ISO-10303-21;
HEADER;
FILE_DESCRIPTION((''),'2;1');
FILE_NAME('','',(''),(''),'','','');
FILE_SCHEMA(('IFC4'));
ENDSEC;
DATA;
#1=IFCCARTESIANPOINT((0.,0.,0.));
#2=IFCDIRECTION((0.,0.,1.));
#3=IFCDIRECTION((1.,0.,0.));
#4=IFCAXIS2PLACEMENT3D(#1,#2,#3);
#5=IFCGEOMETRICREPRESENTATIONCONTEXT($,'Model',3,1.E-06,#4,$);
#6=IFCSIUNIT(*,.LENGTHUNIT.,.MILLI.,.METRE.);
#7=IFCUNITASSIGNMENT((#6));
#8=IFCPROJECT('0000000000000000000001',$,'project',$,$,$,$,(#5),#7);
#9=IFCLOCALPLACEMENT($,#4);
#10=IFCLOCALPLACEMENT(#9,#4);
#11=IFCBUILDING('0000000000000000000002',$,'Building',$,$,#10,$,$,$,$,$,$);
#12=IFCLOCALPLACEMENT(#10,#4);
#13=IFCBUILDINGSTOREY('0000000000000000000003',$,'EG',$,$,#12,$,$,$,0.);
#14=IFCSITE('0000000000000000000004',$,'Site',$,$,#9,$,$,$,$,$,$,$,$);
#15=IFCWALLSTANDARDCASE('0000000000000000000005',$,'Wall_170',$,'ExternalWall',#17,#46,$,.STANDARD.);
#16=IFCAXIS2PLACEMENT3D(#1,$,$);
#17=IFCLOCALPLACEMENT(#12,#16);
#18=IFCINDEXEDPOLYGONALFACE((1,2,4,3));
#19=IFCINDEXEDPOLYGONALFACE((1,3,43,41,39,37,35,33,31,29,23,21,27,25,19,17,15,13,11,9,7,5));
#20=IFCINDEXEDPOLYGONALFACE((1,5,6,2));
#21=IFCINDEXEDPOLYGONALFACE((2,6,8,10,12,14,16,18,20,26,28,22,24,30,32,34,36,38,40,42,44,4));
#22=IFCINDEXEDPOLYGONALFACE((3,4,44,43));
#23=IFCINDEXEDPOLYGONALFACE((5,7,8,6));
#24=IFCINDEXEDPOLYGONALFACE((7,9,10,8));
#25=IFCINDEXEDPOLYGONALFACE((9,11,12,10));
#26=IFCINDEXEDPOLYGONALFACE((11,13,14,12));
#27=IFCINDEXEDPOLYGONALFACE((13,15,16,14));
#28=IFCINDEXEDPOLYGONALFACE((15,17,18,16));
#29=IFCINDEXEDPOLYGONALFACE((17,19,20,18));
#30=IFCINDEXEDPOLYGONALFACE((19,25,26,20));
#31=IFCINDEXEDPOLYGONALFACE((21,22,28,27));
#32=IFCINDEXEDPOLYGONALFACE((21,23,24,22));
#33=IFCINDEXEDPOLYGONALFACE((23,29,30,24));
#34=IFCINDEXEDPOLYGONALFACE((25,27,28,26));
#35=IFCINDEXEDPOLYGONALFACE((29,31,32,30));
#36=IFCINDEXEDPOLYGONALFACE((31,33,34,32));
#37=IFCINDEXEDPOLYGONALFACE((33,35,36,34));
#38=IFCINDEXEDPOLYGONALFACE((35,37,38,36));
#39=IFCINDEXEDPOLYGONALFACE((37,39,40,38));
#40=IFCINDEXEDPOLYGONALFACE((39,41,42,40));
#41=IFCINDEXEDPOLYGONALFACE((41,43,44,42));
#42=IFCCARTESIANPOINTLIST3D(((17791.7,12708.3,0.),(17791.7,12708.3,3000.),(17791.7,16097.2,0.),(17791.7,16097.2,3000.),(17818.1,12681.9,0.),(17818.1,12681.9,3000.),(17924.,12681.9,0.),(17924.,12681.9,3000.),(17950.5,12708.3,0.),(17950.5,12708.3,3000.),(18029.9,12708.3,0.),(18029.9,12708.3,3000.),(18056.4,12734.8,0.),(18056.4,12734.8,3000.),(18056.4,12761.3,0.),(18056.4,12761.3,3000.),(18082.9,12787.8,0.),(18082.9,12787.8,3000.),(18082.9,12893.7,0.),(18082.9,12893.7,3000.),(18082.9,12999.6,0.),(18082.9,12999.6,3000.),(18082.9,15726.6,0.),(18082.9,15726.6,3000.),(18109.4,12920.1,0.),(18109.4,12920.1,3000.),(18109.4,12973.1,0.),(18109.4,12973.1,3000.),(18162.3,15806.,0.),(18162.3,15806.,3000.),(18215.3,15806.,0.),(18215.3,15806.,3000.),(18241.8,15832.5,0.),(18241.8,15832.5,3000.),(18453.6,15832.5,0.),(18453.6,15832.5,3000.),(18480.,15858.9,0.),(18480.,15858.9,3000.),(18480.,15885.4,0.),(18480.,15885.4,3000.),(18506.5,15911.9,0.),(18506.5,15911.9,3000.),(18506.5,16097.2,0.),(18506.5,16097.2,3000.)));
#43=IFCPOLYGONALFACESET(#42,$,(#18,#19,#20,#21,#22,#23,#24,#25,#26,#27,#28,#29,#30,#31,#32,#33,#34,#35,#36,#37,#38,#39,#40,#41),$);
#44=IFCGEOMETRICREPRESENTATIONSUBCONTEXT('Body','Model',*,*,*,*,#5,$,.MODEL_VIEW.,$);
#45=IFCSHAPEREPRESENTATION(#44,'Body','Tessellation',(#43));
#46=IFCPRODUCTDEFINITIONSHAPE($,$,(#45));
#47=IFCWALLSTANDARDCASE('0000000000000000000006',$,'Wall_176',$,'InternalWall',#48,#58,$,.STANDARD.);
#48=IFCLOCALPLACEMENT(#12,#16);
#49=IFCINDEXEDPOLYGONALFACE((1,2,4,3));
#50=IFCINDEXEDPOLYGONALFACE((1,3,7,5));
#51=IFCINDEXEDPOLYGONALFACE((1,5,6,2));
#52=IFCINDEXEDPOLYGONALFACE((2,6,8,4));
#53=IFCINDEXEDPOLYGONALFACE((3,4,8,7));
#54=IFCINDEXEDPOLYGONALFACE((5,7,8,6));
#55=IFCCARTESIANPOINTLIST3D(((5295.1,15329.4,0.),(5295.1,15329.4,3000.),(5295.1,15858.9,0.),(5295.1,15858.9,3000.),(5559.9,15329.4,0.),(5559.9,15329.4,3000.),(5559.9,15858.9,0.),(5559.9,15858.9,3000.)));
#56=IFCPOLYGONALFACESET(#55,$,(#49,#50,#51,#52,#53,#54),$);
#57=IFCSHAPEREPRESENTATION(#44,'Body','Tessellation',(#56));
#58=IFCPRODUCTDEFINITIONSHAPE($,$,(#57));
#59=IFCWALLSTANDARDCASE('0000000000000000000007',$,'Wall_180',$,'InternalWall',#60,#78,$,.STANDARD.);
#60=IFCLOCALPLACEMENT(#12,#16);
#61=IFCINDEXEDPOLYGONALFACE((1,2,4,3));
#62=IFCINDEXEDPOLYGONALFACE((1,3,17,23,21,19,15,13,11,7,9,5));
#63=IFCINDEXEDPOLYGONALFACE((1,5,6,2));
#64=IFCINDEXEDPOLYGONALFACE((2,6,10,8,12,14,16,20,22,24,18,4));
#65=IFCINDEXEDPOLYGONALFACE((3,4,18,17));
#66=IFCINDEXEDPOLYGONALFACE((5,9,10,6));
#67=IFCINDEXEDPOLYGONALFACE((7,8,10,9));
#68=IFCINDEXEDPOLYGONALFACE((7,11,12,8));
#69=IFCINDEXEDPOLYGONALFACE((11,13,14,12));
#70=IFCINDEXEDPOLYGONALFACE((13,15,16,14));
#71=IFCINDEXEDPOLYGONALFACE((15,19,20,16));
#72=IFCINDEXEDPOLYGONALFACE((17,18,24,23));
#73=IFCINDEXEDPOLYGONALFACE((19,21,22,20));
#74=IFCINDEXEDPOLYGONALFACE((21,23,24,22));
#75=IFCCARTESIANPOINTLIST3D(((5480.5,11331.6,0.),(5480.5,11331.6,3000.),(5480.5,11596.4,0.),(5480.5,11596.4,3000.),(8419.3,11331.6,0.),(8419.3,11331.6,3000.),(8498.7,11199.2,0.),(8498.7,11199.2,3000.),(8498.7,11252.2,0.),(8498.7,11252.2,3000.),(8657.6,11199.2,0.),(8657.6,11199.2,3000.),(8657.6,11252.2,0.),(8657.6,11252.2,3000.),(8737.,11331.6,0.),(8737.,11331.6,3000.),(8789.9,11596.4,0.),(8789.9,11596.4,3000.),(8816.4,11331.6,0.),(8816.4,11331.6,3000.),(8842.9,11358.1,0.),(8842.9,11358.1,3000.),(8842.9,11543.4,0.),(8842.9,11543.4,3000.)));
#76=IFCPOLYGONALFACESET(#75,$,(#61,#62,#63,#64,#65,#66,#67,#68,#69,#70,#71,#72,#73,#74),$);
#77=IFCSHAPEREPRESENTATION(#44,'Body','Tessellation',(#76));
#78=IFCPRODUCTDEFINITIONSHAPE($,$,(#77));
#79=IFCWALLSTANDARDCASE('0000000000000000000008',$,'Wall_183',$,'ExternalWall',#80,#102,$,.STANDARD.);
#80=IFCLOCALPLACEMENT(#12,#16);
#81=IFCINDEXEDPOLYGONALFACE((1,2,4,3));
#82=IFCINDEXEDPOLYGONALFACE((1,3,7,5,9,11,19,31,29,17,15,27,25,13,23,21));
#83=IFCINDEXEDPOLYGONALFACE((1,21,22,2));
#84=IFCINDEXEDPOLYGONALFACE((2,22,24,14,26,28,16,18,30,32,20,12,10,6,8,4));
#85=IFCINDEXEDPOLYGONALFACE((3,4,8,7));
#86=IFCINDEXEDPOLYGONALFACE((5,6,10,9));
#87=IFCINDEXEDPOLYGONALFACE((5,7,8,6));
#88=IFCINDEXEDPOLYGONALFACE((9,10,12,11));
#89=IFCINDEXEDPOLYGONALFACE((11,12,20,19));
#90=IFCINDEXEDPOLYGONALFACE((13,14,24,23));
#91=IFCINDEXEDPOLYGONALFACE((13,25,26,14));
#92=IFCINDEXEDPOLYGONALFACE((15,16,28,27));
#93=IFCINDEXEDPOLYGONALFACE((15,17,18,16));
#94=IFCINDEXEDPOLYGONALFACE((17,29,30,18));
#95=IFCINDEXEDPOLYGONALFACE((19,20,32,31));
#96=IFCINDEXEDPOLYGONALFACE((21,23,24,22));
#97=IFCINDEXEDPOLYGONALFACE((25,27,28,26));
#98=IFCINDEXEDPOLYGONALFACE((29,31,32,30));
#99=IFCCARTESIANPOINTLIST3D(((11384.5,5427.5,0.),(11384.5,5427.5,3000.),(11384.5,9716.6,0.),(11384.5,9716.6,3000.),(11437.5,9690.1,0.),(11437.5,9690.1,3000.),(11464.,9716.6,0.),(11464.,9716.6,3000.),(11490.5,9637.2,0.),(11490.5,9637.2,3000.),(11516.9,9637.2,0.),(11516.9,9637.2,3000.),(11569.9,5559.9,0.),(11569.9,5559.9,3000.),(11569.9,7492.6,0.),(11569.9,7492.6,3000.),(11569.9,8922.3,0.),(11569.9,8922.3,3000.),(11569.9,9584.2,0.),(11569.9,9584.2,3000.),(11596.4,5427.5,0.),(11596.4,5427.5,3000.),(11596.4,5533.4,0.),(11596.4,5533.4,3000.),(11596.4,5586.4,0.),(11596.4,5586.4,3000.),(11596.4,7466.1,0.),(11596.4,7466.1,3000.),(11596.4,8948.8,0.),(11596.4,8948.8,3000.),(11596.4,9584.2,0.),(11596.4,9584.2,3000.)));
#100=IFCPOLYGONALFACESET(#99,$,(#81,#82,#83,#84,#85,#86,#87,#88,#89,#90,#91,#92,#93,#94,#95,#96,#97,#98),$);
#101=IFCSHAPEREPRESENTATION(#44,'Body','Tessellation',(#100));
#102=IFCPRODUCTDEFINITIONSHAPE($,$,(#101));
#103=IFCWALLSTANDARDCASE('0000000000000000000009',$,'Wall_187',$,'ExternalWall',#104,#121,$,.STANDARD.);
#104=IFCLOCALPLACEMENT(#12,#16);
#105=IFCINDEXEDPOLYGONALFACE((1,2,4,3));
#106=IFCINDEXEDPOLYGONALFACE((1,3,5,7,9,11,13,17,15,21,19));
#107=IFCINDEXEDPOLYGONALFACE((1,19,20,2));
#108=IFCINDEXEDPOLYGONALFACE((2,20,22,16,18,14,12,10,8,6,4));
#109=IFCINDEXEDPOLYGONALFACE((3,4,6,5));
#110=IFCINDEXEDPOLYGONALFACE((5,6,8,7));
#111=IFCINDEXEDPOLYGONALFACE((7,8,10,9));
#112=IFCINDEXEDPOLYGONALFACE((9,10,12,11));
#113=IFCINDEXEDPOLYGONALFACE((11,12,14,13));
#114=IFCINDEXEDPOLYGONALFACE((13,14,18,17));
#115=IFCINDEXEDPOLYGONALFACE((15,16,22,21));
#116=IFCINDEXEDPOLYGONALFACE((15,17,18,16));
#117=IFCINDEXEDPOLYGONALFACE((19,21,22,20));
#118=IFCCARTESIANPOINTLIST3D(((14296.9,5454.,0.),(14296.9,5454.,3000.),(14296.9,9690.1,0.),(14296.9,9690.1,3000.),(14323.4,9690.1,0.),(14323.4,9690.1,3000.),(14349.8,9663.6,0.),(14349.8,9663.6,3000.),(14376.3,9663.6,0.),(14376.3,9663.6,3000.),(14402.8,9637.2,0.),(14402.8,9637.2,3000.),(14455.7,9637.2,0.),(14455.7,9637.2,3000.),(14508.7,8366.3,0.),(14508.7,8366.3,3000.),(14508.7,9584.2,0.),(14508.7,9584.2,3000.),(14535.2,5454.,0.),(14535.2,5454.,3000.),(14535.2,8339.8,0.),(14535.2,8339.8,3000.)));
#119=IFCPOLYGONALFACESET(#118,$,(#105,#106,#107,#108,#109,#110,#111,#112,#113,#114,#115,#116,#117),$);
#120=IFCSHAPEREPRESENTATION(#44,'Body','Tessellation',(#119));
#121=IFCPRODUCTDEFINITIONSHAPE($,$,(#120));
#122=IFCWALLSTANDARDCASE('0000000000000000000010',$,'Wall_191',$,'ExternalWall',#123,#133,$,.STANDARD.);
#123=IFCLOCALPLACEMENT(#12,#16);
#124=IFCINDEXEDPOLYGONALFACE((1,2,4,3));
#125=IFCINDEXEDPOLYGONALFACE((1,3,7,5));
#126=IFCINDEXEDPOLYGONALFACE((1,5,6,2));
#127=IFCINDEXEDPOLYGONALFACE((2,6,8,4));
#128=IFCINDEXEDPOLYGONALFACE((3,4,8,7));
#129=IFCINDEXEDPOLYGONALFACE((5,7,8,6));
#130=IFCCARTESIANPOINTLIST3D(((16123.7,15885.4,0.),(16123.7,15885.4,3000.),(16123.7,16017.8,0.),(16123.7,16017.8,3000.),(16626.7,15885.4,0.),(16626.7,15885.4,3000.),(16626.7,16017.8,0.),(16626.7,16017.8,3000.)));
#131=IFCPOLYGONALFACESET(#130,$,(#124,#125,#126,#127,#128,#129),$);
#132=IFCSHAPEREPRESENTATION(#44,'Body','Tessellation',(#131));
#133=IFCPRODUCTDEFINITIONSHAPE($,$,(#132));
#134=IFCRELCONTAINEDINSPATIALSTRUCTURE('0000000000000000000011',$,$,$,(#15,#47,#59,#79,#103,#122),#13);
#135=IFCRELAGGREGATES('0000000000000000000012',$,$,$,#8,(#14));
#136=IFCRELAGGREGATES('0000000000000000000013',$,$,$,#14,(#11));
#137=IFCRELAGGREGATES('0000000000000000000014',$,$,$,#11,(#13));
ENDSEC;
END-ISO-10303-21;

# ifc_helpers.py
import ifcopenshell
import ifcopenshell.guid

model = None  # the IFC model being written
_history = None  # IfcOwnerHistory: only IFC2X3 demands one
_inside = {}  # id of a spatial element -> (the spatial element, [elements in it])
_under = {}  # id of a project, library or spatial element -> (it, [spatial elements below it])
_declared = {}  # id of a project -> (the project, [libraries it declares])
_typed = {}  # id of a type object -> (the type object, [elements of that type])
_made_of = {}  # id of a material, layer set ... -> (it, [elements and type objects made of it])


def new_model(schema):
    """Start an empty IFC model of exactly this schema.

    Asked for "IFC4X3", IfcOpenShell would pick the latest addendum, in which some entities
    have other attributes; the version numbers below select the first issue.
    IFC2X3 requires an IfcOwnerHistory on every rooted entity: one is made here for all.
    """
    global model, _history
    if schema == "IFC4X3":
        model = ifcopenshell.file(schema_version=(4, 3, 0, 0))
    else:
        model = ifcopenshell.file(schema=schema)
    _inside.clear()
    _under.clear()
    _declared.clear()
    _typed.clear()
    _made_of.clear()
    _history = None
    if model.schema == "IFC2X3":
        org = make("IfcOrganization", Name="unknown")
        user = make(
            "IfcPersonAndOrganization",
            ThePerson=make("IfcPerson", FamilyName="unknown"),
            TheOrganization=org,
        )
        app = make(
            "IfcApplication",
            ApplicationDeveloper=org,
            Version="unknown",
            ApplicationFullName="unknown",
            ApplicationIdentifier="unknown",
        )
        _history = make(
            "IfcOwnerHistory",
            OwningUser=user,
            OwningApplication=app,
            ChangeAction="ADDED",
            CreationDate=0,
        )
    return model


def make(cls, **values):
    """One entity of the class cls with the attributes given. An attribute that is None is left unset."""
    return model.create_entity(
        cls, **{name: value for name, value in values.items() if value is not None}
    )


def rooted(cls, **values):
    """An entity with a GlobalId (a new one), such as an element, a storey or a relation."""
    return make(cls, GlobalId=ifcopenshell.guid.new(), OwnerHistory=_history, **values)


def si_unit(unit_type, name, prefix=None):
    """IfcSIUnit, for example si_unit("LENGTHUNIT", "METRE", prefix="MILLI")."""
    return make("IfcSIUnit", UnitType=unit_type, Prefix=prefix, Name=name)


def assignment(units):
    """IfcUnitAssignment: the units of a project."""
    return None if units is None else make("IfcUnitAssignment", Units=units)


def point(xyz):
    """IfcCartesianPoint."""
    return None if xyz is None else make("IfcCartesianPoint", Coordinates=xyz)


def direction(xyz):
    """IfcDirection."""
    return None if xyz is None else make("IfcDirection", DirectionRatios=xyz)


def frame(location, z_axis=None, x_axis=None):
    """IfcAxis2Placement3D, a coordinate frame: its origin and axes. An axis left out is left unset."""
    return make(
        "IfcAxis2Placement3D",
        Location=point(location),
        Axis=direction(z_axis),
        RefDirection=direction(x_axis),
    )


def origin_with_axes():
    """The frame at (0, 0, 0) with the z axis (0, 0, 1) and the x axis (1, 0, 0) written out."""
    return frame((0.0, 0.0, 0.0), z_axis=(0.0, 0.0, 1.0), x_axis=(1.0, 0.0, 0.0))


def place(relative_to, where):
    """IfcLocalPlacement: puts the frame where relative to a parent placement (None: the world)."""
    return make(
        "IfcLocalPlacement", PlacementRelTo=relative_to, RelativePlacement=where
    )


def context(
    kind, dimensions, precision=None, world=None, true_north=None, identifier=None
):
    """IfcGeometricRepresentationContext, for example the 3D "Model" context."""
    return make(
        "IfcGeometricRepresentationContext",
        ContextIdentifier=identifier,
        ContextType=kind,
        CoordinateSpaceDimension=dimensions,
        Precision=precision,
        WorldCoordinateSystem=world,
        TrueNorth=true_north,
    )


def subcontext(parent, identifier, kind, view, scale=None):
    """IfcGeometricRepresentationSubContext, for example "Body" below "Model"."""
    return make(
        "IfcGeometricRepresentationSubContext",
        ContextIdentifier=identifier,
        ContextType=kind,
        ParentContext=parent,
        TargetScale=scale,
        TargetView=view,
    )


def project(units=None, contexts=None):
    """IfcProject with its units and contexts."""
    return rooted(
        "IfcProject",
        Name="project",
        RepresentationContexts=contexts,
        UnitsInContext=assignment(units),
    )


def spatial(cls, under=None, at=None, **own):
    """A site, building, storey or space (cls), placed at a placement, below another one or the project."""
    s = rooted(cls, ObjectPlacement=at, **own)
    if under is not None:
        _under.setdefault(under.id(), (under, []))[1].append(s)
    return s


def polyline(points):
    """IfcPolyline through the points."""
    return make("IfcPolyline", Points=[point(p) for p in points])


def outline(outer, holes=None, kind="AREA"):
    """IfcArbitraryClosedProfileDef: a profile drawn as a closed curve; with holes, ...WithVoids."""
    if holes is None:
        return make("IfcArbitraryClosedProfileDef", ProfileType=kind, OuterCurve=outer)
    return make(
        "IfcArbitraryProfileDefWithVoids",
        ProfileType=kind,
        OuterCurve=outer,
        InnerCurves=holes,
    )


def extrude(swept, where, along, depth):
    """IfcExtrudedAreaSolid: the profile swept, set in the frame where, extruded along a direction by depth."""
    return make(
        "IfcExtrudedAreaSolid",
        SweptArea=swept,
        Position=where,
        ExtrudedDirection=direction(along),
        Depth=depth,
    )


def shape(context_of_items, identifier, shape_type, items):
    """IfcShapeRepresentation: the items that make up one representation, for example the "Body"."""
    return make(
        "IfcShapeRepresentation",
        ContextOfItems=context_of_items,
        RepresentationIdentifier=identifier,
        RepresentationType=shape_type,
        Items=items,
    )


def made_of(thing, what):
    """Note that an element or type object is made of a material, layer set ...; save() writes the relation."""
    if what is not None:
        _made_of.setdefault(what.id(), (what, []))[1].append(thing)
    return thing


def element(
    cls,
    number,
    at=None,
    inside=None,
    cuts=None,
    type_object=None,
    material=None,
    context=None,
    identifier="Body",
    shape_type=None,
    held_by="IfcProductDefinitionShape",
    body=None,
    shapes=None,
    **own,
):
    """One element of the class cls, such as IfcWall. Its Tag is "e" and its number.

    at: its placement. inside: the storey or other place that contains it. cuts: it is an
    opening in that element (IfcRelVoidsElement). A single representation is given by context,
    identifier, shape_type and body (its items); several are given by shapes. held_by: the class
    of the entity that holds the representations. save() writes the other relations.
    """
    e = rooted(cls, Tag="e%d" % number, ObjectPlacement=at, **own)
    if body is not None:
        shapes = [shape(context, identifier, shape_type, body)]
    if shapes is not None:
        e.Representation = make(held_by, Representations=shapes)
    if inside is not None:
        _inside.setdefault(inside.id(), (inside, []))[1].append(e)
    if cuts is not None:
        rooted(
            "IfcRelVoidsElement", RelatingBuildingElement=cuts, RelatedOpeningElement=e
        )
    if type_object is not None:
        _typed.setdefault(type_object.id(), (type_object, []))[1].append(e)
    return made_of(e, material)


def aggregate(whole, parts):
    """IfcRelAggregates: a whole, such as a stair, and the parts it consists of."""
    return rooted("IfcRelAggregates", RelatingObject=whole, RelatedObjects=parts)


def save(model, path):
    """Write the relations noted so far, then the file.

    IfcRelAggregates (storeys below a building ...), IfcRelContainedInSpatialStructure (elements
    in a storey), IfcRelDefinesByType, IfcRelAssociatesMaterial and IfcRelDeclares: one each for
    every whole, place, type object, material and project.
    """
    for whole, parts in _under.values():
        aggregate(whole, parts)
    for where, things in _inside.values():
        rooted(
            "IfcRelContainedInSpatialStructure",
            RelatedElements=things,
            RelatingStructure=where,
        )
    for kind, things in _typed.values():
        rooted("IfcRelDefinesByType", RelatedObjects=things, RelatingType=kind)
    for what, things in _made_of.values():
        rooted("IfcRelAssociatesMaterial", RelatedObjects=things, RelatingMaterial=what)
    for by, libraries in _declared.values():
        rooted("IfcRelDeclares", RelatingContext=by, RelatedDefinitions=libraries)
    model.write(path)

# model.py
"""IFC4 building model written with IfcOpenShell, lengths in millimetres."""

from ifc_helpers import new_model, si_unit, frame, origin_with_axes, place, context, subcontext, project, spatial, polyline, outline, extrude, element, save


model = new_model("IFC4")

# Units and contexts
model_context = context("Model", 3, precision=1e-06, world=origin_with_axes())
body_context = subcontext(model_context, "Body", "Model", "MODEL_VIEW")
ifc_project = project(units=[si_unit("LENGTHUNIT", "METRE", prefix="MILLI")], contexts=[model_context])

# Site, building, storey
site_placement = place(None, origin_with_axes())
site = spatial("IfcSite", under=ifc_project, at=site_placement, Name="Site")
building_placement = place(site_placement, origin_with_axes())
building = spatial("IfcBuilding", under=site, at=building_placement, Name="Building")
storey_placement = place(building_placement, origin_with_axes())
storey = spatial("IfcBuildingStorey", under=building, at=storey_placement, Name="EG", Elevation=0.0)

# Walls
for number, where, z_axis, x_axis, name in (
    (1, (0.0, 0.0, 0.0), (0.0, 0.0, 1.0), (1.0, 0.0, 0.0), "Wall_170"),
):
    element("IfcWallStandardCase", number, at=place(storey_placement, frame(where, z_axis=z_axis, x_axis=x_axis)), inside=storey, Name=name, ObjectType="ExternalWall", PredefinedType="STANDARD", context=body_context, shape_type="SweptSolid", body=[
        extrude(outline(polyline([(17818.1, 12681.9, 0.0), (17791.7, 12708.3, 0.0), (17791.7, 16097.2, 0.0), (18506.5, 16097.2, 0.0), (18506.5, 15911.9, 0.0), (18480.0, 15885.4, 0.0), (18480.0, 15858.9, 0.0), (18453.6, 15832.5, 0.0), (18241.8, 15832.5, 0.0), (18215.3, 15806.0, 0.0), (18162.3, 15806.0, 0.0), (18082.9, 15726.6, 0.0), (18082.9, 12999.6, 0.0), (18109.4, 12973.1, 0.0), (18109.4, 12920.1, 0.0), (18082.9, 12893.7, 0.0), (18082.9, 12787.8, 0.0), (18056.4, 12761.3, 0.0), (18056.4, 12734.8, 0.0), (18029.9, 12708.3, 0.0), (17950.5, 12708.3, 0.0), (17924.0, 12681.9, 0.0), (17818.1, 12681.9, 0.0)])), origin_with_axes(), (0.0, 0.0, 1.0), 3000.0),
    ])
for number, where, z_axis, x_axis, name in (
    (2, (0.0, 0.0, 0.0), (0.0, 0.0, 1.0), (1.0, 0.0, 0.0), "Wall_176"),
):
    element("IfcWallStandardCase", number, at=place(storey_placement, frame(where, z_axis=z_axis, x_axis=x_axis)), inside=storey, Name=name, ObjectType="InternalWall", PredefinedType="STANDARD", context=body_context, shape_type="SweptSolid", body=[
        extrude(outline(polyline([(5295.1, 15329.4, 0.0), (5295.1, 15858.9, 0.0), (5559.9, 15858.9, 0.0), (5559.9, 15329.4, 0.0), (5295.1, 15329.4, 0.0)])), origin_with_axes(), (0.0, 0.0, 1.0), 3000.0),
    ])
for number, where, z_axis, x_axis, name in (
    (3, (0.0, 0.0, 0.0), (0.0, 0.0, 1.0), (1.0, 0.0, 0.0), "Wall_180"),
):
    element("IfcWallStandardCase", number, at=place(storey_placement, frame(where, z_axis=z_axis, x_axis=x_axis)), inside=storey, Name=name, ObjectType="InternalWall", PredefinedType="STANDARD", context=body_context, shape_type="SweptSolid", body=[
        extrude(outline(polyline([(8498.7, 11199.2, 0.0), (8498.7, 11252.2, 0.0), (8419.3, 11331.6, 0.0), (5480.5, 11331.6, 0.0), (5480.5, 11596.4, 0.0), (8789.9, 11596.4, 0.0), (8842.9, 11543.4, 0.0), (8842.9, 11358.1, 0.0), (8816.4, 11331.6, 0.0), (8737.0, 11331.6, 0.0), (8657.6, 11252.2, 0.0), (8657.6, 11199.2, 0.0), (8498.7, 11199.2, 0.0)])), origin_with_axes(), (0.0, 0.0, 1.0), 3000.0),
    ])
for number, where, z_axis, x_axis, name in (
    (4, (0.0, 0.0, 0.0), (0.0, 0.0, 1.0), (1.0, 0.0, 0.0), "Wall_183"),
):
    element("IfcWallStandardCase", number, at=place(storey_placement, frame(where, z_axis=z_axis, x_axis=x_axis)), inside=storey, Name=name, ObjectType="ExternalWall", PredefinedType="STANDARD", context=body_context, shape_type="SweptSolid", body=[
        extrude(outline(polyline([(11384.5, 5427.5, 0.0), (11384.5, 9716.6, 0.0), (11464.0, 9716.6, 0.0), (11437.5, 9690.1, 0.0), (11490.5, 9637.2, 0.0), (11516.9, 9637.2, 0.0), (11569.9, 9584.2, 0.0), (11596.4, 9584.2, 0.0), (11596.4, 8948.8, 0.0), (11569.9, 8922.3, 0.0), (11569.9, 7492.6, 0.0), (11596.4, 7466.1, 0.0), (11596.4, 5586.4, 0.0), (11569.9, 5559.9, 0.0), (11596.4, 5533.4, 0.0), (11596.4, 5427.5, 0.0), (11384.5, 5427.5, 0.0)])), origin_with_axes(), (0.0, 0.0, 1.0), 3000.0),
    ])
for number, where, z_axis, x_axis, name in (
    (5, (0.0, 0.0, 0.0), (0.0, 0.0, 1.0), (1.0, 0.0, 0.0), "Wall_187"),
):
    element("IfcWallStandardCase", number, at=place(storey_placement, frame(where, z_axis=z_axis, x_axis=x_axis)), inside=storey, Name=name, ObjectType="ExternalWall", PredefinedType="STANDARD", context=body_context, shape_type="SweptSolid", body=[
        extrude(outline(polyline([(14296.9, 5454.0, 0.0), (14296.9, 9690.1, 0.0), (14323.4, 9690.1, 0.0), (14349.8, 9663.6, 0.0), (14376.3, 9663.6, 0.0), (14402.8, 9637.2, 0.0), (14455.7, 9637.2, 0.0), (14508.7, 9584.2, 0.0), (14508.7, 8366.3, 0.0), (14535.2, 8339.8, 0.0), (14535.2, 5454.0, 0.0), (14296.9, 5454.0, 0.0)])), origin_with_axes(), (0.0, 0.0, 1.0), 3000.0),
    ])
wall_1_placement = place(storey_placement, origin_with_axes())
element("IfcWallStandardCase", 6, at=wall_1_placement, inside=storey, Name="Wall_191", ObjectType="ExternalWall", PredefinedType="STANDARD", context=body_context, shape_type="SweptSolid", body=[
    extrude(outline(polyline([(16123.7, 15885.4, 0.0), (16123.7, 16017.8, 0.0), (16626.7, 16017.8, 0.0), (16626.7, 15885.4, 0.0), (16123.7, 15885.4, 0.0)])), origin_with_axes(), (0.0, 0.0, 1.0), 3000.0),
])

save(model, "model.ifc")
